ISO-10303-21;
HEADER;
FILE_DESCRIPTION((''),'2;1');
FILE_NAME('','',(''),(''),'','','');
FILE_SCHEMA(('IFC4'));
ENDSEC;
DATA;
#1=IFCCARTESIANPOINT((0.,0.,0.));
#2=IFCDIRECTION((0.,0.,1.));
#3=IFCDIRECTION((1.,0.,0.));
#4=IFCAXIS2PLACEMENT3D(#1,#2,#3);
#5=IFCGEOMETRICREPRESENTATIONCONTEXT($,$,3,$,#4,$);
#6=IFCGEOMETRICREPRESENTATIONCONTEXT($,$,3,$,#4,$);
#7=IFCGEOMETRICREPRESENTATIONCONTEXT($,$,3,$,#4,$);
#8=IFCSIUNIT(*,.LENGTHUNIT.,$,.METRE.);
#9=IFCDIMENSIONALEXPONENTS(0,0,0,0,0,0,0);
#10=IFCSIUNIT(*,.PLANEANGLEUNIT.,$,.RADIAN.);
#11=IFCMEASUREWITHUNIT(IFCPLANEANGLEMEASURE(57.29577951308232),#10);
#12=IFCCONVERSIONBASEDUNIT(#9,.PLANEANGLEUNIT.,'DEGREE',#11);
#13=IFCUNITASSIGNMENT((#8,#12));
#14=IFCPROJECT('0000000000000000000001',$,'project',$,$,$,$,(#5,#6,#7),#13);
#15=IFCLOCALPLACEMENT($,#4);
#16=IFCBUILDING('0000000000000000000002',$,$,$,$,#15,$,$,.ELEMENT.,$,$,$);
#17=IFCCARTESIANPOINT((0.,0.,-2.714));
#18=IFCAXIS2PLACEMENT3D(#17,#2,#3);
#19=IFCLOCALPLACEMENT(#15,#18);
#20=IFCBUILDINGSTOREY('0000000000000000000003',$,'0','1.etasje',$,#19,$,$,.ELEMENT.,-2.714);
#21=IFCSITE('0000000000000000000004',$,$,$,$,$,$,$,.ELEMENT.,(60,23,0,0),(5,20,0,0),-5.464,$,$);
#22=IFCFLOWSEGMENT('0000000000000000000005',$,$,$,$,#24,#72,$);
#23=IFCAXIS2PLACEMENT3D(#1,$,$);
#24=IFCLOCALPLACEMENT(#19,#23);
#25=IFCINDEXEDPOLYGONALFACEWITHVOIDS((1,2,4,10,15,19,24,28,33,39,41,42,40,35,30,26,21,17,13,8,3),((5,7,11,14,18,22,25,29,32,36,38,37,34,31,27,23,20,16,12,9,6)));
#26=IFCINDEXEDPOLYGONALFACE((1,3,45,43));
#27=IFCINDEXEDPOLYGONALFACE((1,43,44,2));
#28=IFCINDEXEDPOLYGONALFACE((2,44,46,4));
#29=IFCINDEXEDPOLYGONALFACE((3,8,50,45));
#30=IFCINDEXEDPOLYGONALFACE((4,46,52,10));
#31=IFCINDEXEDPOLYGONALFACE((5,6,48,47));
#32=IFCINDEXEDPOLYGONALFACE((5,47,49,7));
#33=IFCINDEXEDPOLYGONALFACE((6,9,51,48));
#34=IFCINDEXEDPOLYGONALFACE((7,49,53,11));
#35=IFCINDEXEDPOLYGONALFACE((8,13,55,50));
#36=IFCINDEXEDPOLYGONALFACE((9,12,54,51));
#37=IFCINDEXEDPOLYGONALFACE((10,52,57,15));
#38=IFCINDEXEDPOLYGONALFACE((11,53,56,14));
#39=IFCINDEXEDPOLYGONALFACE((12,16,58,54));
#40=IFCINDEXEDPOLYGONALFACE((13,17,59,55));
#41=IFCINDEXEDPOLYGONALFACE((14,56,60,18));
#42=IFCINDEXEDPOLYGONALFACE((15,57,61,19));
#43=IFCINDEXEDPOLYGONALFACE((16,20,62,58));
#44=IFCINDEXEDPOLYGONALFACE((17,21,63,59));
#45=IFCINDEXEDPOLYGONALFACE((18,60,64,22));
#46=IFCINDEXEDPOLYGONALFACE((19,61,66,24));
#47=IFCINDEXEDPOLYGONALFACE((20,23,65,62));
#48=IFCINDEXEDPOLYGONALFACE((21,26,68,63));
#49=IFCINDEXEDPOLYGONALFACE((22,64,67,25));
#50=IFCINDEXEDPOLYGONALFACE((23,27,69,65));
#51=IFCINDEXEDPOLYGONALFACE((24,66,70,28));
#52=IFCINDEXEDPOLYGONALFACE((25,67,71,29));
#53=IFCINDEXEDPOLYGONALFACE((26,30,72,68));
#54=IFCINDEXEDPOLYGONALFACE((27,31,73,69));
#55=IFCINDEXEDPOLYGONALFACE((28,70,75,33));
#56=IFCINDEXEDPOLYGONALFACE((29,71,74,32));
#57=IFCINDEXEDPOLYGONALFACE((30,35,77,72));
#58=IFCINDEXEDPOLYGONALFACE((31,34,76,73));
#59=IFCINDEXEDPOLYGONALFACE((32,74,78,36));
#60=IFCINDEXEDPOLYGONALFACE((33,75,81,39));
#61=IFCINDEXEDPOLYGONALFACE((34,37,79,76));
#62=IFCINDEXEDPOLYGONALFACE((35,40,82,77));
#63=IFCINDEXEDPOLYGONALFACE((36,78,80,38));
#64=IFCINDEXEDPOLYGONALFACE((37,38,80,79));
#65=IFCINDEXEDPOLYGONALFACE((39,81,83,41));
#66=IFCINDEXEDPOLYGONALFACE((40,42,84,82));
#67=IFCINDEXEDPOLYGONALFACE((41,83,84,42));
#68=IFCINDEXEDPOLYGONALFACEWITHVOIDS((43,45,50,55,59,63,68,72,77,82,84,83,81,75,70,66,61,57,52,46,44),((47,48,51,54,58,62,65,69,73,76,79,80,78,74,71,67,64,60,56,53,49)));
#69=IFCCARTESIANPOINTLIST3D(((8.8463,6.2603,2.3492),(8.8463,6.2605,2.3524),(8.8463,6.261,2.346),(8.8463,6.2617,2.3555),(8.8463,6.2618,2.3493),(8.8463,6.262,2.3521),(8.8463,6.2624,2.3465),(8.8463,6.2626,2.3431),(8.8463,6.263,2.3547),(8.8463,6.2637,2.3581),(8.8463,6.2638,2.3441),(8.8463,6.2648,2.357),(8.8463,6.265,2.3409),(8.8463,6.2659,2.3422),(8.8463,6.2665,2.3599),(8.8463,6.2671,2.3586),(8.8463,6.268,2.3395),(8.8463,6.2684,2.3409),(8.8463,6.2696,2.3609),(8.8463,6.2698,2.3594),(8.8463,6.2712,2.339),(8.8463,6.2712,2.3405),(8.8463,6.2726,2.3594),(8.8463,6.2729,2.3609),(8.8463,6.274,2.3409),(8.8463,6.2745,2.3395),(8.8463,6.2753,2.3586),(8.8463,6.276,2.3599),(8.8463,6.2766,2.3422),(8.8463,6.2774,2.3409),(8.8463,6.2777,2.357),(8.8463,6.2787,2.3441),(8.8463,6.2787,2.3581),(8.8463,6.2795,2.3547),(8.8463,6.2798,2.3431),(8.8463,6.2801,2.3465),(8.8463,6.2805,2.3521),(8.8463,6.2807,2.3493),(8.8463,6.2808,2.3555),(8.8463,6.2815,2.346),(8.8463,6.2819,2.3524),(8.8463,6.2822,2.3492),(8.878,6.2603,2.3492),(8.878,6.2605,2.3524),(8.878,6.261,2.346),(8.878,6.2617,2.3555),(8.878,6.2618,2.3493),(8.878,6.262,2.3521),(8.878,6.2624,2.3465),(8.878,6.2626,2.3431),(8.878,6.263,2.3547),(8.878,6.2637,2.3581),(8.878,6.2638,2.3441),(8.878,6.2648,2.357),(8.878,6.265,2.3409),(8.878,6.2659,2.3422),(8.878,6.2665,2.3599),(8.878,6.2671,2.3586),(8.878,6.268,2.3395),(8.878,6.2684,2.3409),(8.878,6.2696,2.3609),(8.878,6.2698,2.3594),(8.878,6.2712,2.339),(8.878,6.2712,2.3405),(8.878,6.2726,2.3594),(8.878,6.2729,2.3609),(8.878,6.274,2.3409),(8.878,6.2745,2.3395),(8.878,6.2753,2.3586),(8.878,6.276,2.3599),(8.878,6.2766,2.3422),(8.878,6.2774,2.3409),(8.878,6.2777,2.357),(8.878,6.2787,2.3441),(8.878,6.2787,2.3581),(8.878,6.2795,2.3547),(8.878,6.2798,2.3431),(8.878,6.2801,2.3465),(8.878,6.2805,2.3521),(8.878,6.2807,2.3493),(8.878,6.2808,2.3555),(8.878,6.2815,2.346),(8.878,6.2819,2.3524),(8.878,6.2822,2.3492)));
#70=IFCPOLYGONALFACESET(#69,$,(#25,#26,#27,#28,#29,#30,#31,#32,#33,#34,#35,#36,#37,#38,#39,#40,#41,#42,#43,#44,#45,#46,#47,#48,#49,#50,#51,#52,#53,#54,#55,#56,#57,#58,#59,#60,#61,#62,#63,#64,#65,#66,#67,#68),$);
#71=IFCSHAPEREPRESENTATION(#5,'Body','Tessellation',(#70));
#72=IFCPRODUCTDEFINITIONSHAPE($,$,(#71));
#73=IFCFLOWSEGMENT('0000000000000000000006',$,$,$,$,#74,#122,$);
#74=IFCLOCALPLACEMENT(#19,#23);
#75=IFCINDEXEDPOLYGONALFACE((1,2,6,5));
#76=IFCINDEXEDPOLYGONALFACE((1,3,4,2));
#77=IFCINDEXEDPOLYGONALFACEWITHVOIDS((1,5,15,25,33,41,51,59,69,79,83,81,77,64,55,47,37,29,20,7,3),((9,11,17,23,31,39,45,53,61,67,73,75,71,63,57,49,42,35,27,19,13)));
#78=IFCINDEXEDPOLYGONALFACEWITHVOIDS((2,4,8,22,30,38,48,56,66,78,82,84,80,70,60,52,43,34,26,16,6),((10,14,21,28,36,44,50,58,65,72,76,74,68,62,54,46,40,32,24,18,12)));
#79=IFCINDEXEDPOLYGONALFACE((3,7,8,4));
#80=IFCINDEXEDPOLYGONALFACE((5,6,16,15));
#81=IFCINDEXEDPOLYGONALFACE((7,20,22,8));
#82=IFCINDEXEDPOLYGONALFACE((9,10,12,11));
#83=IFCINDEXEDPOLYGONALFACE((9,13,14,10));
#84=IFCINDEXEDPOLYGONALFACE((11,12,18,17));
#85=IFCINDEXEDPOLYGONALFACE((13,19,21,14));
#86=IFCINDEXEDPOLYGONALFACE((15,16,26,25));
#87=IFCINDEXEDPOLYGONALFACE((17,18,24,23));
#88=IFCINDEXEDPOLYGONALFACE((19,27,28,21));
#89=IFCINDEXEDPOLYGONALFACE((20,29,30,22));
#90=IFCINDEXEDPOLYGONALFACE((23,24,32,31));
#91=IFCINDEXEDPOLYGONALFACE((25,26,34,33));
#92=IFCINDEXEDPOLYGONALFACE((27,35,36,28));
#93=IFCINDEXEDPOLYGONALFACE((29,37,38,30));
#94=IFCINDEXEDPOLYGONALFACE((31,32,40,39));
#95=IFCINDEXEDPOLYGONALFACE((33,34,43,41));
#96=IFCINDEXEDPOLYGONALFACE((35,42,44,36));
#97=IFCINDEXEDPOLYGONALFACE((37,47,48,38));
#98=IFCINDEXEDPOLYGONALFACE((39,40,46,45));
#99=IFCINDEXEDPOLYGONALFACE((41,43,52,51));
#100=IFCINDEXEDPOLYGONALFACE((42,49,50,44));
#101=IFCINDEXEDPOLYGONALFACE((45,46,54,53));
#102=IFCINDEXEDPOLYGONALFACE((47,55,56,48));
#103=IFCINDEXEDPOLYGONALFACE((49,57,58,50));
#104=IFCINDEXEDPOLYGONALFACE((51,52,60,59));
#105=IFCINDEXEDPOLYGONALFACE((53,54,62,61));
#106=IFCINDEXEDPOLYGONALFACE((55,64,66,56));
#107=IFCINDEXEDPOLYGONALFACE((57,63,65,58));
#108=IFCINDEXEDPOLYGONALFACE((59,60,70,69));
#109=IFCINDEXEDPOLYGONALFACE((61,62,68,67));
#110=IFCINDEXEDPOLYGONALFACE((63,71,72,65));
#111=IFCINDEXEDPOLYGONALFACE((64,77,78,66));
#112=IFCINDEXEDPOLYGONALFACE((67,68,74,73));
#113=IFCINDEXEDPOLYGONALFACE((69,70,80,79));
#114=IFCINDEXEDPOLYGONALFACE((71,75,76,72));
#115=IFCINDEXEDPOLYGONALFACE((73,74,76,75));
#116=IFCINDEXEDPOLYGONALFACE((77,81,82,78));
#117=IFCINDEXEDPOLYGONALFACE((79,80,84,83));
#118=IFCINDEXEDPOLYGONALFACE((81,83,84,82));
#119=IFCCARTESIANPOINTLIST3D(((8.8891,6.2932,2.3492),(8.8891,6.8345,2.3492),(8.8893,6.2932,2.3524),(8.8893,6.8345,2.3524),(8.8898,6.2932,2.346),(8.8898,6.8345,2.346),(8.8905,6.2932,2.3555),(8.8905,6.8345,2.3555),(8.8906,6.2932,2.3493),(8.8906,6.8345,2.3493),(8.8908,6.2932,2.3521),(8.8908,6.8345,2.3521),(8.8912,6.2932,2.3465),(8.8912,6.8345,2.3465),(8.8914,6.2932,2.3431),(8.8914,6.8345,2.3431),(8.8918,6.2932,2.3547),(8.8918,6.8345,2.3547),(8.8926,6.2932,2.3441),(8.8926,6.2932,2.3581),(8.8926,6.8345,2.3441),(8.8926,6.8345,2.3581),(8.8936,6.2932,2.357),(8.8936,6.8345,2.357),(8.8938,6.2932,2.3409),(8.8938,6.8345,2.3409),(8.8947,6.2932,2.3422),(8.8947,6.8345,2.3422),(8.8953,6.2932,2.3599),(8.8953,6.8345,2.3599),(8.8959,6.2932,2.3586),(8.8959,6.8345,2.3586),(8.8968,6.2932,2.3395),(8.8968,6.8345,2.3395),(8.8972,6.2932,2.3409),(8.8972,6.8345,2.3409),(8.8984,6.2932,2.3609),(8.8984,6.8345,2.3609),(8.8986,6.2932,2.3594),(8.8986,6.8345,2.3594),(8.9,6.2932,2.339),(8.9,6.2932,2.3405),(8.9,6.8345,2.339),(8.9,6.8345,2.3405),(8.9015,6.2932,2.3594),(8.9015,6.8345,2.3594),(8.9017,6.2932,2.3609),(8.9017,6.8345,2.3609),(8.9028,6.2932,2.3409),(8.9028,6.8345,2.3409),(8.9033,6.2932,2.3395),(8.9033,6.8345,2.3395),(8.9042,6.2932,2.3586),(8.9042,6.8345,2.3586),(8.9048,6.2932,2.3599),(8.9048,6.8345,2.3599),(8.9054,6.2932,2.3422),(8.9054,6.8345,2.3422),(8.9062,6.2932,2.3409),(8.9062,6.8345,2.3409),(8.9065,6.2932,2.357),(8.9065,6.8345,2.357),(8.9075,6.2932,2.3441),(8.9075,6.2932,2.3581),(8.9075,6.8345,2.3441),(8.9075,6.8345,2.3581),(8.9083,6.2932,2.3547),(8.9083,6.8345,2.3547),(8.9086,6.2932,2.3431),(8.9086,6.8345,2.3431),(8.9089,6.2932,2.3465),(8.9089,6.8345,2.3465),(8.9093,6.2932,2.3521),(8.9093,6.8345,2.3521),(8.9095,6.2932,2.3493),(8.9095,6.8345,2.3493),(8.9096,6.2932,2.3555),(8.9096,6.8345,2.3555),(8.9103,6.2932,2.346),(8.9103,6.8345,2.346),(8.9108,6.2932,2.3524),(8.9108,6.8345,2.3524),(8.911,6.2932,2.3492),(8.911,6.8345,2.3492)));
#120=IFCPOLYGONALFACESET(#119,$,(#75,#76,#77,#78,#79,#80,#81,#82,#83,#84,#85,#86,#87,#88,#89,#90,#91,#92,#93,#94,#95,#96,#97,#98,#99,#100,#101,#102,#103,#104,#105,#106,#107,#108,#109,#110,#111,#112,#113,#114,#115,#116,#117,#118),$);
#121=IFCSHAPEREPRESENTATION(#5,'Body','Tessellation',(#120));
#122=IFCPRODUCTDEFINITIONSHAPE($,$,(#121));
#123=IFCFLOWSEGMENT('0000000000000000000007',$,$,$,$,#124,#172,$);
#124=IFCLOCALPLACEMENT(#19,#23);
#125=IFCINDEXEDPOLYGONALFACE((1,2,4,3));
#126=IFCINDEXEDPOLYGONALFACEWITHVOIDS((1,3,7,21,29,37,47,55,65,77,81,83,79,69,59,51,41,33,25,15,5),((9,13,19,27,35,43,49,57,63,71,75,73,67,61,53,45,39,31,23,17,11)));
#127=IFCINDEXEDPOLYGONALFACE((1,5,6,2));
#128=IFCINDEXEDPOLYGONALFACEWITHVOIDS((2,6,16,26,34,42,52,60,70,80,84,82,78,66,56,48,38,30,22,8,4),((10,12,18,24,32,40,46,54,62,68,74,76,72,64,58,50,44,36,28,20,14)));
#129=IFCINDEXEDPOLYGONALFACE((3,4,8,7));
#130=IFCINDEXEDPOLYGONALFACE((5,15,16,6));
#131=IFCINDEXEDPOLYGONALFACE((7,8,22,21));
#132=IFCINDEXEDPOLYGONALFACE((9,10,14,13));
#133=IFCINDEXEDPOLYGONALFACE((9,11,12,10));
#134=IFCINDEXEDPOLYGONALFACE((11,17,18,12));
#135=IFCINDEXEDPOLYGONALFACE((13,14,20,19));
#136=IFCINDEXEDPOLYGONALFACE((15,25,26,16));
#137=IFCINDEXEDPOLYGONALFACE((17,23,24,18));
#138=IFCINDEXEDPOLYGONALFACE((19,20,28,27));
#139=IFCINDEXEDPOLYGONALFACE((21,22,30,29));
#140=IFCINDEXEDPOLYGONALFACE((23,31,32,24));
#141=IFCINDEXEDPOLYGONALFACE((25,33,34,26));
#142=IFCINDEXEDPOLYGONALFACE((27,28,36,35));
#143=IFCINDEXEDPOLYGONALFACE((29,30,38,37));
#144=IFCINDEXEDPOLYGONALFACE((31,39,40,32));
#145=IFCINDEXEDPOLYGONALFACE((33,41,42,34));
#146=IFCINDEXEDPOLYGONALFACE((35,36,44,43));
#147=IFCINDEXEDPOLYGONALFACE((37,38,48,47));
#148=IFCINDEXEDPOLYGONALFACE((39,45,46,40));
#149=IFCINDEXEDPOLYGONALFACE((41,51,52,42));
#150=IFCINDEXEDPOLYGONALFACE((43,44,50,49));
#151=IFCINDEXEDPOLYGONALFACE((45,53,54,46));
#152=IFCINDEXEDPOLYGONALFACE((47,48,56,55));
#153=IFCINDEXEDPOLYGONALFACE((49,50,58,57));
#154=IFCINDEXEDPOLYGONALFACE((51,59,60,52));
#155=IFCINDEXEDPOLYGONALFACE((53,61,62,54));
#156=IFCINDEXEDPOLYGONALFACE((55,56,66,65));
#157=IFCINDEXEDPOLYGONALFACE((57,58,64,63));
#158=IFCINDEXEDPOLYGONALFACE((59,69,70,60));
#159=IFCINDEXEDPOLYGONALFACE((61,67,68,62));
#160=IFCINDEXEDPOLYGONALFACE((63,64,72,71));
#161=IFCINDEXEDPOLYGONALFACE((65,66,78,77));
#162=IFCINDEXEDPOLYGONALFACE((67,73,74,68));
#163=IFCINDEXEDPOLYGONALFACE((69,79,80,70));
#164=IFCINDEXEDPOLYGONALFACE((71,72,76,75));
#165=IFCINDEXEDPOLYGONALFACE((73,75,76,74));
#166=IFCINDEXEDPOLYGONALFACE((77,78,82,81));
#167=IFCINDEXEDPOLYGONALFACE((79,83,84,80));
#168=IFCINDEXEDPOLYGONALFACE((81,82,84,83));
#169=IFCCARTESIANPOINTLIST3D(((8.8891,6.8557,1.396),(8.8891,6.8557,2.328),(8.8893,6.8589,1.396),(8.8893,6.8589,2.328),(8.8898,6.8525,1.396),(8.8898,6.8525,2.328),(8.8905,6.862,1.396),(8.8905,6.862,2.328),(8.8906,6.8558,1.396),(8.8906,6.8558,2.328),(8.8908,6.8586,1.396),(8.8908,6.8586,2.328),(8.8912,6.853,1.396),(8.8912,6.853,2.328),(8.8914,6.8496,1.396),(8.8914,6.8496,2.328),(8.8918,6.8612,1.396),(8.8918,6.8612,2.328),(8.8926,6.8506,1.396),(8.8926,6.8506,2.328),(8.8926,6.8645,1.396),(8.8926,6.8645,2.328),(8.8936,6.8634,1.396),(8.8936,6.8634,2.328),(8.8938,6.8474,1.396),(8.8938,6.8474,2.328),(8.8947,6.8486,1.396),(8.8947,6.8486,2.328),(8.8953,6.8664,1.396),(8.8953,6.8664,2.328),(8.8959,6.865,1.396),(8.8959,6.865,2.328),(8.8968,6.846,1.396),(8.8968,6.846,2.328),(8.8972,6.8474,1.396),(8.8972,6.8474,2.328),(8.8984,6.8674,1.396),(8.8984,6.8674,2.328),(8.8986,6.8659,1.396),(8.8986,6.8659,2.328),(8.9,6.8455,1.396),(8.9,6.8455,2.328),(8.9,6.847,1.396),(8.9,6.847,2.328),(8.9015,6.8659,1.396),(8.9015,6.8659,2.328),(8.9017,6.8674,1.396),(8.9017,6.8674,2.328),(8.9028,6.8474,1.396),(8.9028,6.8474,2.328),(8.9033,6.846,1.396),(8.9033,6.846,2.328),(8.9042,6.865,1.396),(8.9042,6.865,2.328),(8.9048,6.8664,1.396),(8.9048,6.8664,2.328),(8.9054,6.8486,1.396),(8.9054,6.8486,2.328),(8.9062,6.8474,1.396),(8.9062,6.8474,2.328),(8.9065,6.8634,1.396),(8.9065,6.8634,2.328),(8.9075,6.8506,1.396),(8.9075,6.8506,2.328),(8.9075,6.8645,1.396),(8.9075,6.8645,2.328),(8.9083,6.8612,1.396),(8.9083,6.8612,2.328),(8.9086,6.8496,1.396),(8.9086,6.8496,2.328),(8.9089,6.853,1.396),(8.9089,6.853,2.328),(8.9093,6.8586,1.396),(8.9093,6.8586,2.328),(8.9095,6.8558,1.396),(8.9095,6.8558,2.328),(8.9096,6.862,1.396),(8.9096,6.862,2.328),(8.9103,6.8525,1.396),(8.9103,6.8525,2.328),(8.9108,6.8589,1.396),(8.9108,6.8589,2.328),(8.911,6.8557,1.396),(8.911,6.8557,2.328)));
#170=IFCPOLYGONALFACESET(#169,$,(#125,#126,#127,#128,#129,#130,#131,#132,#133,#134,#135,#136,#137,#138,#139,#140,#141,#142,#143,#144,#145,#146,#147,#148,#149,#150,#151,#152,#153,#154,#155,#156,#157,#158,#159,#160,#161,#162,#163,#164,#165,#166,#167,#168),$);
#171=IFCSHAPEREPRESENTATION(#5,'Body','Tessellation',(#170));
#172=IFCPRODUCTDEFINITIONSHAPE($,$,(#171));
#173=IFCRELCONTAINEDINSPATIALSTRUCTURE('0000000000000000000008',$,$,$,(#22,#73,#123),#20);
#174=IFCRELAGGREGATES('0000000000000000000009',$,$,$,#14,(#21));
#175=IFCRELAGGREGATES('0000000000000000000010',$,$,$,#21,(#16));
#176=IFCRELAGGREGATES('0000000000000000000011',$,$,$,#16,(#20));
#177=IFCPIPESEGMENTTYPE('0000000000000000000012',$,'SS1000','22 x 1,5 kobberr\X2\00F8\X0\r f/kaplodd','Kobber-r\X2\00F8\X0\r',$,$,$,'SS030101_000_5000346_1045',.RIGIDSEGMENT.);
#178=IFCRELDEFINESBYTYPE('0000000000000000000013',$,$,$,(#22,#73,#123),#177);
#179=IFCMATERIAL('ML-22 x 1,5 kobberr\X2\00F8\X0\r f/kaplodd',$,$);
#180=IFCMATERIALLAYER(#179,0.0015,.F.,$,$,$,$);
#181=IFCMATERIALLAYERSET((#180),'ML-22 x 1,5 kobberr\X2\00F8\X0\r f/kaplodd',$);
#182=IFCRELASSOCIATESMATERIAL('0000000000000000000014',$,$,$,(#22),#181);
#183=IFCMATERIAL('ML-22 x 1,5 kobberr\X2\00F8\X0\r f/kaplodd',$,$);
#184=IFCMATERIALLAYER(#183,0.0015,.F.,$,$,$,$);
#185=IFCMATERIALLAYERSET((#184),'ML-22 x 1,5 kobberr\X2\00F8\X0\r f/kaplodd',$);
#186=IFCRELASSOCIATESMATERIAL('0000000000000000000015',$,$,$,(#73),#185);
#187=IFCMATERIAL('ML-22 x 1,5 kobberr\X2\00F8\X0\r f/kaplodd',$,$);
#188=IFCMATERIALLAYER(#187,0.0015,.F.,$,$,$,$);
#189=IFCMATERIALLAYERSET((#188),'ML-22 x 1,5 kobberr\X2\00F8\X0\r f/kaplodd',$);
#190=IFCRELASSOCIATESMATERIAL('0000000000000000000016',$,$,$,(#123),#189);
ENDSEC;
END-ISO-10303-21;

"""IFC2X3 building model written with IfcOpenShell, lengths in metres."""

from ifc_helpers import new_model, entity, si_unit, converted_unit, frame, origin_with_axes, origin_2d_with_axis, place, context, project, spatial, hollow_circle, extrude, material, layer, layer_set, layer_usage, type_object, element, save


model = new_model("IFC2X3")

# Units and contexts
context_of_model_1 = context(None, 3, world=origin_with_axes())
context_of_model_2 = context(None, 3, world=origin_with_axes())
context_of_model_3 = context(None, 3, world=origin_with_axes())
ifc_project = project(units=[si_unit("LENGTHUNIT", "METRE"), converted_unit("PLANEANGLEUNIT", "DEGREE", entity("IfcPlaneAngleMeasure", 57.29577951308232), si_unit("PLANEANGLEUNIT", "RADIAN"), dimensions=[0, 0, 0, 0, 0, 0, 0])], contexts=[context_of_model_1, context_of_model_2, context_of_model_3])

# Site, building, storey
site = spatial("IfcSite", under=ifc_project, CompositionType="ELEMENT", RefLatitude=(60, 23, 0, 0), RefLongitude=(5, 20, 0, 0), RefElevation=-5.464)
building_placement = place(None, origin_with_axes())
building = spatial("IfcBuilding", under=site, at=building_placement, CompositionType="ELEMENT")
storey_placement = place(building_placement, frame((0.0, 0.0, -2.714), z_axis=(0.0, 0.0, 1.0), x_axis=(1.0, 0.0, 0.0)))
storey = spatial("IfcBuildingStorey", under=building, at=storey_placement, Name="0", Description="1.etasje", CompositionType="ELEMENT", Elevation=-2.714)

# Flow segments
pipe_segment_type_1 = type_object("IfcPipeSegmentType", Name="SS1000", Description="22 x 1,5 kobberrør f/kaplodd", ApplicableOccurrence="Kobber-rør", ElementType="SS030101_000_5000346_1045", PredefinedType="RIGIDSEGMENT")
ifc_material_1 = material(Name="ML-22 x 1,5 kobberrør f/kaplodd")
ifc_layer_1 = layer(ifc_material_1, 0.0015, ventilated=False)
ifc_layer_set_1 = layer_set([ifc_layer_1], Name="ML-22 x 1,5 kobberrør f/kaplodd")
ifc_layer_usage_1 = layer_usage(ifc_layer_set_1, "AXIS2", "POSITIVE", 0.0)
flow_segment_1_placement = place(storey_placement, frame((8.8463, 6.2712, 2.35), z_axis=(1.0, 0.0, 0.0), x_axis=(0.0, 0.0, -1.0)))
element("IfcFlowSegment", 1, at=flow_segment_1_placement, inside=storey, type_object=pipe_segment_type_1, material=ifc_layer_usage_1, context=context_of_model_1, shape_type="SweptSolid", body=[
    extrude(hollow_circle(Radius=0.011, WallThickness=0.0015, at=origin_2d_with_axis()), origin_with_axes(), (0.0, 0.0, 1.0), 0.0318),
])
ifc_material_2 = material(Name="ML-22 x 1,5 kobberrør f/kaplodd")
ifc_layer_2 = layer(ifc_material_2, 0.0015, ventilated=False)
ifc_layer_set_2 = layer_set([ifc_layer_2], Name="ML-22 x 1,5 kobberrør f/kaplodd")
ifc_layer_usage_2 = layer_usage(ifc_layer_set_2, "AXIS2", "POSITIVE", 0.0)
flow_segment_2_placement = place(storey_placement, frame((8.9, 6.2932, 2.35), z_axis=(0.0, 1.0, 0.0), x_axis=(0.0, 0.0, -1.0)))
element("IfcFlowSegment", 2, at=flow_segment_2_placement, inside=storey, type_object=pipe_segment_type_1, material=ifc_layer_usage_2, context=context_of_model_1, shape_type="SweptSolid", body=[
    extrude(hollow_circle(Radius=0.011, WallThickness=0.0015, at=origin_2d_with_axis()), origin_with_axes(), (0.0, 0.0, 1.0), 0.5413),
])
ifc_material_3 = material(Name="ML-22 x 1,5 kobberrør f/kaplodd")
ifc_layer_3 = layer(ifc_material_3, 0.0015, ventilated=False)
ifc_layer_set_3 = layer_set([ifc_layer_3], Name="ML-22 x 1,5 kobberrør f/kaplodd")
ifc_layer_usage_3 = layer_usage(ifc_layer_set_3, "AXIS2", "POSITIVE", 0.0)
flow_segment_3_placement = place(storey_placement, frame((8.9, 6.8565, 2.328), z_axis=(0.0, 0.0, -1.0), x_axis=(0.0, -1.0, 0.0)))
element("IfcFlowSegment", 3, at=flow_segment_3_placement, inside=storey, type_object=pipe_segment_type_1, material=ifc_layer_usage_3, context=context_of_model_1, shape_type="SweptSolid", body=[
    extrude(hollow_circle(Radius=0.011, WallThickness=0.0015, at=origin_2d_with_axis()), origin_with_axes(), (0.0, 0.0, 1.0), 0.932),
])

save(model, "model.ifc")
